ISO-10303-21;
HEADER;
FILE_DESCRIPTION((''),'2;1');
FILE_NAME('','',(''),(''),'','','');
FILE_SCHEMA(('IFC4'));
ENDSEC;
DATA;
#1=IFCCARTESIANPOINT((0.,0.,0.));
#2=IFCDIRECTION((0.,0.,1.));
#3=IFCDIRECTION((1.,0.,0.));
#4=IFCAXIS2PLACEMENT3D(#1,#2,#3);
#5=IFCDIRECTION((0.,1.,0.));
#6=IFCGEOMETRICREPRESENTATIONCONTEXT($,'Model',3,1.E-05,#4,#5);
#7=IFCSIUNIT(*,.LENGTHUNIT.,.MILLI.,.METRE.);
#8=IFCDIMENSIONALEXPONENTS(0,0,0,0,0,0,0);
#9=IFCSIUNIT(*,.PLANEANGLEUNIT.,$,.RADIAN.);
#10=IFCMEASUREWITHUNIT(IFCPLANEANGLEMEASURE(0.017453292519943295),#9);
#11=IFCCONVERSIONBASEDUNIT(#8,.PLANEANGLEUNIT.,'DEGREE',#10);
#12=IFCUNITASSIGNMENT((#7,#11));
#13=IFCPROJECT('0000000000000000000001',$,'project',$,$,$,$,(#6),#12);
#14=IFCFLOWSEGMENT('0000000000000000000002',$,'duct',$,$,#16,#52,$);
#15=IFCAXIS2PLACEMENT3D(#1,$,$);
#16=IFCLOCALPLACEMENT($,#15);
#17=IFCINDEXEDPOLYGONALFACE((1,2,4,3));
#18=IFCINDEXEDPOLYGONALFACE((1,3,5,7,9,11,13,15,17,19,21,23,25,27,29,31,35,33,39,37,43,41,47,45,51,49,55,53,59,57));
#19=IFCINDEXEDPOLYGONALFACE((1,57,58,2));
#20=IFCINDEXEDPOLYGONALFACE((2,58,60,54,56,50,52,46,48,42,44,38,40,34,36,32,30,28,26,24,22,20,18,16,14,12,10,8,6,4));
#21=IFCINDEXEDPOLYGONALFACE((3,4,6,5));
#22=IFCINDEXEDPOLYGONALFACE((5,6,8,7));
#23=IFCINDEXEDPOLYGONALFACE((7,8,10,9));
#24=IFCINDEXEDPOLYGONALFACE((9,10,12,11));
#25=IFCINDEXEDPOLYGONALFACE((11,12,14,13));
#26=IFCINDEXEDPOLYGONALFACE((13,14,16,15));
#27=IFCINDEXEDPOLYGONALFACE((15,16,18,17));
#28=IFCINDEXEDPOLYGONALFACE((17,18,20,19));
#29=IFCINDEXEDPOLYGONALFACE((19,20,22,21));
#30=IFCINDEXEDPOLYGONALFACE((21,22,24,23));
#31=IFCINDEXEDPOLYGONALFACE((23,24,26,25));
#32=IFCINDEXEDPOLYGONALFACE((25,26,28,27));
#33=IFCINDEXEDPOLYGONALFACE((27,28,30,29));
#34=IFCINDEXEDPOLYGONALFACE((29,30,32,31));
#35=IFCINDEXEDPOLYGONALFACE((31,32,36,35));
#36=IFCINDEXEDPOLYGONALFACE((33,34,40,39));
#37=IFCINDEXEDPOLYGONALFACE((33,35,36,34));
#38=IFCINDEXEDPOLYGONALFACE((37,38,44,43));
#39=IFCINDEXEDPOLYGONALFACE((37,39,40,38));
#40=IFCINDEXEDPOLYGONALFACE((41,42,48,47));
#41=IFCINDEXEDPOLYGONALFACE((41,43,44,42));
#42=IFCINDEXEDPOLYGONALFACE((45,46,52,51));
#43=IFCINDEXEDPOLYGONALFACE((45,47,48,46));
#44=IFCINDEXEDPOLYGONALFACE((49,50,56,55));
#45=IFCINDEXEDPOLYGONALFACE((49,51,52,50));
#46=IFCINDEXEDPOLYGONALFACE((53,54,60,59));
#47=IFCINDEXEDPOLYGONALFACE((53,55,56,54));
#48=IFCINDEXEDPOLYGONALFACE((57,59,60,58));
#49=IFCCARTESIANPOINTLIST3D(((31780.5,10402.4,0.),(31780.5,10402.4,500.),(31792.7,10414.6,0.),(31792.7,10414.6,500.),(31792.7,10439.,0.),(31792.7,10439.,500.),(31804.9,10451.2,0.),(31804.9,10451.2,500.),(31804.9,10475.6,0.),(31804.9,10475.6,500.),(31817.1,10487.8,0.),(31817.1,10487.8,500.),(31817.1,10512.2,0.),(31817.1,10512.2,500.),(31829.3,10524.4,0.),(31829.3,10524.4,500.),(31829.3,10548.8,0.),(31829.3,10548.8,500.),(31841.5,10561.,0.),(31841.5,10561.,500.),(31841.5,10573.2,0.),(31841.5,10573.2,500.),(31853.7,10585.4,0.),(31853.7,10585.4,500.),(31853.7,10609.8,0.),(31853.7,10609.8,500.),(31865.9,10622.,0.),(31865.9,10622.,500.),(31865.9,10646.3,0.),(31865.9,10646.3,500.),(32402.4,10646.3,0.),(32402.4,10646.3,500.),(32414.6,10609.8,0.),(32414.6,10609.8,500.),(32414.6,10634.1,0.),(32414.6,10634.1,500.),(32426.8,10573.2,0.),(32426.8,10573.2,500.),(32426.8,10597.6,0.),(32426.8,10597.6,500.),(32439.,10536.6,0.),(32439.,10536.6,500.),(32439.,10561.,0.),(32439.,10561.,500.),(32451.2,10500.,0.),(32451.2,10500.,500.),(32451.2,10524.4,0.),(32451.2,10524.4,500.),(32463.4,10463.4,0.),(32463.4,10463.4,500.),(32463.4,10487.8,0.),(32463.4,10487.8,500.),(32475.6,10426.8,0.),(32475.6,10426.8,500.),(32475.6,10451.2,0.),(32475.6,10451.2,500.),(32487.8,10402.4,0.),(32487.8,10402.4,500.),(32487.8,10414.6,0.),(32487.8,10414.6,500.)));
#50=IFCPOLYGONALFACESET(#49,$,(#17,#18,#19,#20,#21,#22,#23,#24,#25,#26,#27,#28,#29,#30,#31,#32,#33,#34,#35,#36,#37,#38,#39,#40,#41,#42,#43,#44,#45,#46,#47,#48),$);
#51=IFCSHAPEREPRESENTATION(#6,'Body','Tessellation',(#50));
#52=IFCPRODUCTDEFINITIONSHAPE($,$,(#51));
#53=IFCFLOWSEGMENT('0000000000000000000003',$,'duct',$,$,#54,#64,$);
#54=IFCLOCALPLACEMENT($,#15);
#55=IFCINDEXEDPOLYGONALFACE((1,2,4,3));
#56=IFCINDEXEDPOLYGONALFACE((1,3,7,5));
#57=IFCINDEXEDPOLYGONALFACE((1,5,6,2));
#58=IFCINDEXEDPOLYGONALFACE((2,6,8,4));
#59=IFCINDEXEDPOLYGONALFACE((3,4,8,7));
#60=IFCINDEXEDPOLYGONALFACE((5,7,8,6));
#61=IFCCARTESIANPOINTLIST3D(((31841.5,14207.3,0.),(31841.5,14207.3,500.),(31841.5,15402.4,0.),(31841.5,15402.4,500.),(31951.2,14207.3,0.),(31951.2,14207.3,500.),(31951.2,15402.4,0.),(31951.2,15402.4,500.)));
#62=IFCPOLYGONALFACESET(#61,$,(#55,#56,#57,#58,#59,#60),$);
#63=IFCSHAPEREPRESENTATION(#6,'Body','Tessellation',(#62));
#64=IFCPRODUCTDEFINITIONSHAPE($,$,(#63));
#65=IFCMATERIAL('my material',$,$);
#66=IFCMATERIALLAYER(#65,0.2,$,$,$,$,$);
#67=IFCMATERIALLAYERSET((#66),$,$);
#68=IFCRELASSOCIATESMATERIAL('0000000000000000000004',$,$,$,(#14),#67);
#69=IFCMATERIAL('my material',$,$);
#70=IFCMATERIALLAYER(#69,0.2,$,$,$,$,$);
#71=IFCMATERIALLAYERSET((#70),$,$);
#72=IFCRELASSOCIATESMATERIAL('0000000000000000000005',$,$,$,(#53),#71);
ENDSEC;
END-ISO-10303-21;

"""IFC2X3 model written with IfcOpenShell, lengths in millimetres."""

from ifc_helpers import new_model, entity, si_unit, converted_unit, direction, origin_with_axes, place, context, project, polyline, outline, extrude, material, layer, layer_set, layer_usage, element, save


model = new_model("IFC2X3")

# Units and contexts
model_context = context("Model", 3, precision=1e-05, world=origin_with_axes(), true_north=direction((0.0, 1.0, 0.0)))
ifc_project = project(units=[si_unit("LENGTHUNIT", "METRE", prefix="MILLI"), converted_unit("PLANEANGLEUNIT", "DEGREE", entity("IfcPlaneAngleMeasure", 0.017453292519943295), si_unit("PLANEANGLEUNIT", "RADIAN"), dimensions=[0, 0, 0, 0, 0, 0, 0])], contexts=[model_context])

# Flow segments
ifc_material_1 = material(Name="my material")
ifc_layer_1 = layer(ifc_material_1, 0.2)
ifc_layer_set_1 = layer_set([ifc_layer_1])
ifc_layer_usage_1 = layer_usage(ifc_layer_set_1, "AXIS2", "POSITIVE", -0.1)
flow_segment_1_placement = place(None, origin_with_axes())
element("IfcFlowSegment", 1, at=flow_segment_1_placement, material=ifc_layer_usage_1, Name="duct", context=model_context, shape_type="SweptSolid", body=[
    extrude(outline(polyline([(31780.5, 10402.4), (32487.8, 10402.4), (32487.8, 10414.6), (32475.6, 10426.8), (32475.6, 10451.2), (32463.4, 10463.4), (32463.4, 10487.8), (32451.2, 10500.0), (32451.2, 10524.4), (32439.0, 10536.6), (32439.0, 10561.0), (32426.8, 10573.2), (32426.8, 10597.6), (32414.6, 10609.8), (32414.6, 10634.1), (32402.4, 10646.3), (31865.9, 10646.3), (31865.9, 10622.0), (31853.7, 10609.8), (31853.7, 10585.4), (31841.5, 10573.2), (31841.5, 10561.0), (31829.3, 10548.8), (31829.3, 10524.4), (31817.1, 10512.2), (31817.1, 10487.8), (31804.9, 10475.6), (31804.9, 10451.2), (31792.7, 10439.0), (31792.7, 10414.6), (31780.5, 10402.4)])), origin_with_axes(), (0.0, 0.0, 1.0), 500.0),
])
ifc_material_2 = material(Name="my material")
ifc_layer_2 = layer(ifc_material_2, 0.2)
ifc_layer_set_2 = layer_set([ifc_layer_2])
ifc_layer_usage_2 = layer_usage(ifc_layer_set_2, "AXIS2", "POSITIVE", -0.1)
flow_segment_2_placement = place(None, origin_with_axes())
element("IfcFlowSegment", 2, at=flow_segment_2_placement, material=ifc_layer_usage_2, Name="duct", context=model_context, shape_type="SweptSolid", body=[
    extrude(outline(polyline([(31841.5, 14207.3), (31951.2, 14207.3), (31951.2, 15402.4), (31841.5, 15402.4), (31841.5, 14207.3)])), origin_with_axes(), (0.0, 0.0, 1.0), 500.0),
])

save(model, "model.ifc")
